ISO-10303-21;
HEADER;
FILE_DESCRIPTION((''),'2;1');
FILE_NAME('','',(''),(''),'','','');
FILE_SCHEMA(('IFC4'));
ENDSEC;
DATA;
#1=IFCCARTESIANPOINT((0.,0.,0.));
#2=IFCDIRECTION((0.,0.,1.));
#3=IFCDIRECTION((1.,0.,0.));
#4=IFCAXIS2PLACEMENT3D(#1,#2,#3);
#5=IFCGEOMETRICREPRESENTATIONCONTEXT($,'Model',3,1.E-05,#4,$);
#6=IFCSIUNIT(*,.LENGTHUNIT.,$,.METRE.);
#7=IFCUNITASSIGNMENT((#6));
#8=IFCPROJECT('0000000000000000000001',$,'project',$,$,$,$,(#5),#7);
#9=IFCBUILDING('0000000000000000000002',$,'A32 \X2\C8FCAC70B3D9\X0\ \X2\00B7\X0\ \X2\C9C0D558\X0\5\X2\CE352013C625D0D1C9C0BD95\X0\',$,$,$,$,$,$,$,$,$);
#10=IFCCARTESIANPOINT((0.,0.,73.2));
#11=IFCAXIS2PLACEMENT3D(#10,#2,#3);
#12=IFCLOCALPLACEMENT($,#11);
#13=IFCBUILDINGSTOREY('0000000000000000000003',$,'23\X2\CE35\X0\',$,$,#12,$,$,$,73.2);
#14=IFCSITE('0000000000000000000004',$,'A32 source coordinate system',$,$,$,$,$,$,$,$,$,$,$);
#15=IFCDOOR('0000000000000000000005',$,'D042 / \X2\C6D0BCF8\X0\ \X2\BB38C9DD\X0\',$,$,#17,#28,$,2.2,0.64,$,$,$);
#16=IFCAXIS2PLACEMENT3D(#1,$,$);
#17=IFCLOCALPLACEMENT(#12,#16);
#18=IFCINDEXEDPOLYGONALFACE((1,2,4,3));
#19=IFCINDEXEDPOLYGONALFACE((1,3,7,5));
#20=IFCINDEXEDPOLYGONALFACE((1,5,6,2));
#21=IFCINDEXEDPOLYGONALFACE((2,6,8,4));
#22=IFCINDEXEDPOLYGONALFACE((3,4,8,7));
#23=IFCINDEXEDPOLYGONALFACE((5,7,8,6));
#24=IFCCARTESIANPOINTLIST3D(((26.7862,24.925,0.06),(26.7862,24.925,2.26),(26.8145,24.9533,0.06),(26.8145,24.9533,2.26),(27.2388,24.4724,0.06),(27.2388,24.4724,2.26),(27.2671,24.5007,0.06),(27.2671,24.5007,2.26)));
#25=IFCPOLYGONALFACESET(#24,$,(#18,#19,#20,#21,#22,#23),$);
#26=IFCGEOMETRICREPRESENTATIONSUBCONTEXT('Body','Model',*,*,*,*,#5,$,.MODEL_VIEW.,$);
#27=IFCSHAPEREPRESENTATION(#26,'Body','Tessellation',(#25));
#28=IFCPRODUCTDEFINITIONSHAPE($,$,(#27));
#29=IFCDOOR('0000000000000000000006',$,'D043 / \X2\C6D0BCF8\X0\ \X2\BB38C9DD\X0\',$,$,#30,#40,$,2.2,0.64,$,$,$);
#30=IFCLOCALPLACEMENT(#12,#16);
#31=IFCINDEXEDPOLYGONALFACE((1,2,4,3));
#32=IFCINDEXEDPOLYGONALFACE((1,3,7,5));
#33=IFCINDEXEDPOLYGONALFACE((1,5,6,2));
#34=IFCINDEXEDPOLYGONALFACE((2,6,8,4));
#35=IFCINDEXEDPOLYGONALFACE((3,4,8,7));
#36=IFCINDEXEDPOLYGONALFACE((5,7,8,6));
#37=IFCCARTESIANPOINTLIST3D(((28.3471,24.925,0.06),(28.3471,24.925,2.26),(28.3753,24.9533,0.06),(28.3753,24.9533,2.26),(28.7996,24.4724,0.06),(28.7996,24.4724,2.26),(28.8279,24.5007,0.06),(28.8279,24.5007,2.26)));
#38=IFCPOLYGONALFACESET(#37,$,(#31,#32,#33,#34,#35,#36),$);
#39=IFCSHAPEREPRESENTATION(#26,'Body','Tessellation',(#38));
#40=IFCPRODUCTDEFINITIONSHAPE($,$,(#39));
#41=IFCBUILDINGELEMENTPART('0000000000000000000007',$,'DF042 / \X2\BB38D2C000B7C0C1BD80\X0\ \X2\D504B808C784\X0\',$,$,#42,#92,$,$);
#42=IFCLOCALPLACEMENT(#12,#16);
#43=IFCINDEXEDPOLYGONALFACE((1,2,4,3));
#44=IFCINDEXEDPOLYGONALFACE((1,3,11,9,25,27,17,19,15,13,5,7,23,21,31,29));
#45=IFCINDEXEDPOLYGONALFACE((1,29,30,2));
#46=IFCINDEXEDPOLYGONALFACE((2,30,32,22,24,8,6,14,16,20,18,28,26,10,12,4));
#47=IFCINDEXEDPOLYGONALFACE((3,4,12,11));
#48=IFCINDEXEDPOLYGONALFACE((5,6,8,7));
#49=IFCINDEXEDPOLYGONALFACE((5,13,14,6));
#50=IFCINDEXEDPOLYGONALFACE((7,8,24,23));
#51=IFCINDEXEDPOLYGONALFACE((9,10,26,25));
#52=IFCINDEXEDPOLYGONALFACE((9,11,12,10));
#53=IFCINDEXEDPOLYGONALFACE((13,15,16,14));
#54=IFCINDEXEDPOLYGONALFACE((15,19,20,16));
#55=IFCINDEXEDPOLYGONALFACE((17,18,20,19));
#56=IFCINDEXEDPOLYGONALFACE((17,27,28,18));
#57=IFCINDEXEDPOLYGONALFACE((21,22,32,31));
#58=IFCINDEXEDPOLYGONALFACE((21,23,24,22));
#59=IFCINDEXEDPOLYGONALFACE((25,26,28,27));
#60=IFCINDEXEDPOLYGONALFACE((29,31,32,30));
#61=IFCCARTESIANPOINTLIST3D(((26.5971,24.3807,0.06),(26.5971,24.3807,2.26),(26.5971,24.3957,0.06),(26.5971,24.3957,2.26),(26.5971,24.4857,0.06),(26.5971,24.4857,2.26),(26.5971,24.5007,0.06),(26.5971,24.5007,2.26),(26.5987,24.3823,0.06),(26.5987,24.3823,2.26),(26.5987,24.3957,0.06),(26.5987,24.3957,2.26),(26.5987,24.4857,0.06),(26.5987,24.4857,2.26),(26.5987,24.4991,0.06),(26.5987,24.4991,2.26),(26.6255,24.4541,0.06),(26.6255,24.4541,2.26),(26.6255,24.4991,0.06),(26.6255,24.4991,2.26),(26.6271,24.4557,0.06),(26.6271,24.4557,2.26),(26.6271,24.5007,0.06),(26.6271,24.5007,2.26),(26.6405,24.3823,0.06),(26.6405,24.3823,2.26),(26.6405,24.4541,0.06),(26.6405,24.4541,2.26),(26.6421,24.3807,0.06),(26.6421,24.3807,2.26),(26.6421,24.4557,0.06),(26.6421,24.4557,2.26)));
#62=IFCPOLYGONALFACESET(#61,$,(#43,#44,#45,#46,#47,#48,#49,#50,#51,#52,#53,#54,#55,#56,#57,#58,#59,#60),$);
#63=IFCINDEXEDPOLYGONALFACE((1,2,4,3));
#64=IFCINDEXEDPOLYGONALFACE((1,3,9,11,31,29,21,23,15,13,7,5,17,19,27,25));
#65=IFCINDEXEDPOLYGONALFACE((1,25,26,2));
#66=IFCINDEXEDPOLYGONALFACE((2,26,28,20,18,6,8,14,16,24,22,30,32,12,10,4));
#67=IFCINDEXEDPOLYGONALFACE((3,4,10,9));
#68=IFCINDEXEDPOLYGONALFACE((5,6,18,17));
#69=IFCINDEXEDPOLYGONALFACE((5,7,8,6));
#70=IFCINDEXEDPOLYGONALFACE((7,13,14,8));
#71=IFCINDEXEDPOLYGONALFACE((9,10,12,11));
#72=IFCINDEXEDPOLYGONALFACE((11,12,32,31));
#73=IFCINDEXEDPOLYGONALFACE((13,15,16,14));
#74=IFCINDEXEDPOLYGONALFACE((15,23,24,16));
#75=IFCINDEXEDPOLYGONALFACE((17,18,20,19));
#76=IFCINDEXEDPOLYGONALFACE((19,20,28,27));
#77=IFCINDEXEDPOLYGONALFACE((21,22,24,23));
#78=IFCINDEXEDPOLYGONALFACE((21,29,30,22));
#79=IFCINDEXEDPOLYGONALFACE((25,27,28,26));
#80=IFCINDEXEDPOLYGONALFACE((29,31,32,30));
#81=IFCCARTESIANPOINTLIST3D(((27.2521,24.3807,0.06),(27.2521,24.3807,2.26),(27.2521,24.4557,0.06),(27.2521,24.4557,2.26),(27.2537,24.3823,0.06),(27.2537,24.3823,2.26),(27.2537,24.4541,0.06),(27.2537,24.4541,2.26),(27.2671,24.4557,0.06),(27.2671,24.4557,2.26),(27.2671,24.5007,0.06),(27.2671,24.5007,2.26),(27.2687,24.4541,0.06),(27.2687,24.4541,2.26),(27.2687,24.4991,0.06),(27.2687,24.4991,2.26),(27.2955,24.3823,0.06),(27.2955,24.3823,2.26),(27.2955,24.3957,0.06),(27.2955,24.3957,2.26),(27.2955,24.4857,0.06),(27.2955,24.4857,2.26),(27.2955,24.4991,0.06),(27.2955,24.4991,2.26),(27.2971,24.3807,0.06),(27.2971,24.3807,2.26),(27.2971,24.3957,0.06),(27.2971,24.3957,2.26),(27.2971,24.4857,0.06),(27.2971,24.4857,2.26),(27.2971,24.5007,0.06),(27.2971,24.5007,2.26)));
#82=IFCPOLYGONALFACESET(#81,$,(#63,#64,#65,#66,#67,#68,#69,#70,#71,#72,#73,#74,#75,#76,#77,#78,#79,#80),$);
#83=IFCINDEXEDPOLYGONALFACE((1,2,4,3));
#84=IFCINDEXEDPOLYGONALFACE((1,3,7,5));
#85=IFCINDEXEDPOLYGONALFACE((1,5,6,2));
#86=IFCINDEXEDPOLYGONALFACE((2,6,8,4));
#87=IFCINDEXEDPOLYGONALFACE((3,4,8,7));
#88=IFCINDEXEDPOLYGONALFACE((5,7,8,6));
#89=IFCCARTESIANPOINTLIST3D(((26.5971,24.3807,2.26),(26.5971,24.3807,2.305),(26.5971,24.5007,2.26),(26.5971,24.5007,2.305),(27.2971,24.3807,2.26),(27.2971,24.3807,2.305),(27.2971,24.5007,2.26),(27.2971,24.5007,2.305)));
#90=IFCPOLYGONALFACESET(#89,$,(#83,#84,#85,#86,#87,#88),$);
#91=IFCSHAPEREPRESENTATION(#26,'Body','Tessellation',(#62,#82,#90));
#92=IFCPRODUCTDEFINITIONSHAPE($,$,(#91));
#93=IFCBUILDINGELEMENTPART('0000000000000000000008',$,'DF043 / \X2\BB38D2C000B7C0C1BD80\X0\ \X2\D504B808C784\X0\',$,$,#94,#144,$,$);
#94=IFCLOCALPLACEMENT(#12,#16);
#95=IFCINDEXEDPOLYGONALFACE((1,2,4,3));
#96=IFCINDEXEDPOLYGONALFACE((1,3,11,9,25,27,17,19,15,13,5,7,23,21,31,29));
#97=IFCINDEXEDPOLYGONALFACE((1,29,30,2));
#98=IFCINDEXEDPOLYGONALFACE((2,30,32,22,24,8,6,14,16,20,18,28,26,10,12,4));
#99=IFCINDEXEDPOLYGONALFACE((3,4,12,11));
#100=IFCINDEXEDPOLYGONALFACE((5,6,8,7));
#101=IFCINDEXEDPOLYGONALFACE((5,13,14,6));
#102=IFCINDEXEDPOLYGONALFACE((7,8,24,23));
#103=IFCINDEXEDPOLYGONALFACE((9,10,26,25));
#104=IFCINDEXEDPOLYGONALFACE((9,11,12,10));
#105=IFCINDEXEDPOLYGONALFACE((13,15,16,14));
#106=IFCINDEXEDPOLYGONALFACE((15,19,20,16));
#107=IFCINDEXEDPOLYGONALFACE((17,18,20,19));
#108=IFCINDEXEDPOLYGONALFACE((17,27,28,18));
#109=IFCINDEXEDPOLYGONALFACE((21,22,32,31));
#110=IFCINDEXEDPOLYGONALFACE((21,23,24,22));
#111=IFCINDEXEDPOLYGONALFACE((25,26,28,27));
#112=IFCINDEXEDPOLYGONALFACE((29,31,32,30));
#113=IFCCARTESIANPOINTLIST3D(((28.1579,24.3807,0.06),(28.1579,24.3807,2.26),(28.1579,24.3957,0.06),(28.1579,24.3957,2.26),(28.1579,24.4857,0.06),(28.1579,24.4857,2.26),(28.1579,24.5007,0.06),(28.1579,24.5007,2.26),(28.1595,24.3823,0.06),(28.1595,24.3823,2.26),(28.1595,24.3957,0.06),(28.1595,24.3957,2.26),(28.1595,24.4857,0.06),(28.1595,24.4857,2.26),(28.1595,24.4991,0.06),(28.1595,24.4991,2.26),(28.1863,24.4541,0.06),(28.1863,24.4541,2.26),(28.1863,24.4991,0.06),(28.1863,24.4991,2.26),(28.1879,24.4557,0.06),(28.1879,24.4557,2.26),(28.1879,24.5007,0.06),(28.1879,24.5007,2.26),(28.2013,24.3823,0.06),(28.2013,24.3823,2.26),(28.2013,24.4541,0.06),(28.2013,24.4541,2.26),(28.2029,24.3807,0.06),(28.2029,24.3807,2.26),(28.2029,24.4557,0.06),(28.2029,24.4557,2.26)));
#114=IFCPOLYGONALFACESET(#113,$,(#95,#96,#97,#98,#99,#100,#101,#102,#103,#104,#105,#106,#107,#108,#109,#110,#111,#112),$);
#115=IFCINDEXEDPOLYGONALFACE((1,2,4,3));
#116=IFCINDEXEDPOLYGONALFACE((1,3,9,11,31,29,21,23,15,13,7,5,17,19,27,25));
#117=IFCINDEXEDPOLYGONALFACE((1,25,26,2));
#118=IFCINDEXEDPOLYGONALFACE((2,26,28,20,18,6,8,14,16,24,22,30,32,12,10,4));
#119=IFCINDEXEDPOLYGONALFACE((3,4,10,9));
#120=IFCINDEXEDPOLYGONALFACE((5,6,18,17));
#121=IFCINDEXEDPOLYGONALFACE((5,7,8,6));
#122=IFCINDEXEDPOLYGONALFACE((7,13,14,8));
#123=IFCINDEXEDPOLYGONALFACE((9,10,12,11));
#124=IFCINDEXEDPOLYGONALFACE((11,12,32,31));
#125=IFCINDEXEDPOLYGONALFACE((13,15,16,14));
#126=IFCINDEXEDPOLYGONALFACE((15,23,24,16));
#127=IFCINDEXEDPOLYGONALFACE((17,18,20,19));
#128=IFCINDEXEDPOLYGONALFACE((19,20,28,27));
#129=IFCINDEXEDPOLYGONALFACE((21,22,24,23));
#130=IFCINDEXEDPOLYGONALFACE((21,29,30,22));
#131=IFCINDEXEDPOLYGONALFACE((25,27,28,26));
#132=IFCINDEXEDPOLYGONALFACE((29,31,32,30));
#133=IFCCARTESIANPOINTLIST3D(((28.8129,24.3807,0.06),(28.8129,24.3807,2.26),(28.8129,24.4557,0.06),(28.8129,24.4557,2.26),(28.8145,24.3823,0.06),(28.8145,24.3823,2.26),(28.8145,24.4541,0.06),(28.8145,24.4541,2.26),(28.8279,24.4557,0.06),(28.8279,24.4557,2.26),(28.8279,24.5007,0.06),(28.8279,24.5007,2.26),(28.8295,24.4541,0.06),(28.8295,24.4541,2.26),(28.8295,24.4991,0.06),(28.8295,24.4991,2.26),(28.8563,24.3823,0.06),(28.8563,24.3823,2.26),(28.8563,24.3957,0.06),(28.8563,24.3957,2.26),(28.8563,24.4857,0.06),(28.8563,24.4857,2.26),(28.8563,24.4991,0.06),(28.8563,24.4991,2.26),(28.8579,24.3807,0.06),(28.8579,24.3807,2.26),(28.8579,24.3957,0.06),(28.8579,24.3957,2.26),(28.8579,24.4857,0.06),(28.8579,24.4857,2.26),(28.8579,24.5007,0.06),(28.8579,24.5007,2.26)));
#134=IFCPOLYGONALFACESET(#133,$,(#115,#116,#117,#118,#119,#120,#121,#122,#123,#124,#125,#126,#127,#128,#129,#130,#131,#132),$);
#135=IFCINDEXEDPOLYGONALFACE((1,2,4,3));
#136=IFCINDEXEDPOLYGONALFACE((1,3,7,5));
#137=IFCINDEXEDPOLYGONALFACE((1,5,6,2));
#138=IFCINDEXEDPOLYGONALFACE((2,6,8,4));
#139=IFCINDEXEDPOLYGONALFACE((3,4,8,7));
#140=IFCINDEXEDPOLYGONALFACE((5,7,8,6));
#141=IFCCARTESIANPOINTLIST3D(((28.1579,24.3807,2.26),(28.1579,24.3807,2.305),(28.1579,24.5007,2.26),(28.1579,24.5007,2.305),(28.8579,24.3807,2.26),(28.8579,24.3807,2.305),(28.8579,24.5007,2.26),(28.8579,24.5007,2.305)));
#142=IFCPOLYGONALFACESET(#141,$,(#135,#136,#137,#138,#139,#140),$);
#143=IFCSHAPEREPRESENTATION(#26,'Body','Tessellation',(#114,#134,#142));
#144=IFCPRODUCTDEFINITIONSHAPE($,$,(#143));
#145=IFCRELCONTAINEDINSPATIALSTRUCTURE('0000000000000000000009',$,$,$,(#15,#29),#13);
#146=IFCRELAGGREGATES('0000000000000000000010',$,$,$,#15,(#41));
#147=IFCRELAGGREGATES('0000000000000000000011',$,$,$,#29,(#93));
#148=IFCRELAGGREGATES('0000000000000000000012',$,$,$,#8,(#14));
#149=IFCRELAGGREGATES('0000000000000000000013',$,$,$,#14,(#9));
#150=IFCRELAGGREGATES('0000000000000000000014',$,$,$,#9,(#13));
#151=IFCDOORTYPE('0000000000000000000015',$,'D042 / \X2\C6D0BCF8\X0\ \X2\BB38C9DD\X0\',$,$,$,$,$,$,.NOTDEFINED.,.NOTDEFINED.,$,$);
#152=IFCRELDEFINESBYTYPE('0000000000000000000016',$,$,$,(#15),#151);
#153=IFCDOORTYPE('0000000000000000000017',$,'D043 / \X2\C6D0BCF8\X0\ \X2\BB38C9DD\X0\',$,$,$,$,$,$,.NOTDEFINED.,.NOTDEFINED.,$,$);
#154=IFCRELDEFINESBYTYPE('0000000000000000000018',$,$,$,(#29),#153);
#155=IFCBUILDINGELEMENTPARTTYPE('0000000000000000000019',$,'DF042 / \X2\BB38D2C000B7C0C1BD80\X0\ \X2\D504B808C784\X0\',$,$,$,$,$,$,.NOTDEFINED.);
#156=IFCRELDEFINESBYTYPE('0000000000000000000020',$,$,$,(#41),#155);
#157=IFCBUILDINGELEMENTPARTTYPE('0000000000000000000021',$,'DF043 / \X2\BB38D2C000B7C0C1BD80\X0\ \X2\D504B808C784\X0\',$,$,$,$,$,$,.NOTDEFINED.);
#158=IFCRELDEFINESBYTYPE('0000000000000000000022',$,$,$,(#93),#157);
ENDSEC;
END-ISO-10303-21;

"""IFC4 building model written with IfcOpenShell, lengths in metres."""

from ifc_helpers import new_model, si_unit, frame, origin, origin_with_axes, place, context, subcontext, project, spatial, polyline, outline, extrude, source, transform, mapped, type_object, type_shapes, element, aggregate, save


model = new_model("IFC4")

# Units and contexts
model_context = context("Model", 3, precision=1e-05, world=origin_with_axes())
body_context = subcontext(model_context, "Body", "Model", "MODEL_VIEW")
ifc_project = project(units=[si_unit("LENGTHUNIT", "METRE")], contexts=[model_context])

# Site, building, storey
site = spatial("IfcSite", under=ifc_project, Name="A32 source coordinate system")
building = spatial("IfcBuilding", under=site, Name="A32 주거동 · 지하5층–옥탑지붕")
storey_placement = place(None, frame((0.0, 0.0, 73.2), z_axis=(0.0, 0.0, 1.0), x_axis=(1.0, 0.0, 0.0)))
storey = spatial("IfcBuildingStorey", under=building, at=storey_placement, Name="23층", Elevation=73.2)

# Doors
door_type_1 = type_object("IfcDoorType", Name="D042 / 원본 문짝", OperationType="NOTDEFINED", PredefinedType="NOTDEFINED")
shared_shape_1 = source(origin(), body_context, "Body", "SweptSolid", [
    extrude(outline(polyline([(27.2671, 24.5007), (27.2388, 24.4724), (26.7862, 24.925), (26.8145, 24.9533), (27.2671, 24.5007)])), frame((0.0, 0.0, 0.06)), (0.0, 0.0, 1.0), 2.2),
])
type_shapes(door_type_1, [shared_shape_1])
door_1_placement = place(storey_placement, origin_with_axes())
door_1 = element("IfcDoor", 1, at=door_1_placement, inside=storey, type_object=door_type_1, Name="D042 / 원본 문짝", OverallHeight=2.2, OverallWidth=0.64, context=body_context, shape_type="MappedRepresentation", body=[
    mapped(shared_shape_1, transform((0.0, 0.0, 0.0), scale=1.0)),
])
door_type_2 = type_object("IfcDoorType", Name="D043 / 원본 문짝", OperationType="NOTDEFINED", PredefinedType="NOTDEFINED")
shared_shape_2 = source(origin(), body_context, "Body", "SweptSolid", [
    extrude(outline(polyline([(28.8279, 24.5007), (28.7996, 24.4724), (28.3471, 24.925), (28.3753, 24.9533), (28.8279, 24.5007)])), frame((0.0, 0.0, 0.06)), (0.0, 0.0, 1.0), 2.2),
])
type_shapes(door_type_2, [shared_shape_2])
door_2_placement = place(storey_placement, origin_with_axes())
door_2 = element("IfcDoor", 2, at=door_2_placement, inside=storey, type_object=door_type_2, Name="D043 / 원본 문짝", OverallHeight=2.2, OverallWidth=0.64, context=body_context, shape_type="MappedRepresentation", body=[
    mapped(shared_shape_2, transform((0.0, 0.0, 0.0), scale=1.0)),
])

# Building element parts
building_element_part_type_1 = type_object("IfcBuildingElementPartType", Name="DF042 / 문틀·상부 프레임", PredefinedType="NOTDEFINED")
shared_shape_3 = source(origin(), body_context, "Body", "SweptSolid", [
    extrude(outline(polyline([(26.5971, 24.4857), (26.5971, 24.5007), (26.6271, 24.5007), (26.6271, 24.4557), (26.6421, 24.4557), (26.6421, 24.3807), (26.5971, 24.3807), (26.5971, 24.3957), (26.5987, 24.3957), (26.5987, 24.3823), (26.6405, 24.3823), (26.6405, 24.4541), (26.6255, 24.4541), (26.6255, 24.4991), (26.5987, 24.4991), (26.5987, 24.4857), (26.5971, 24.4857)])), frame((0.0, 0.0, 0.06)), (0.0, 0.0, 1.0), 2.2),
    extrude(outline(polyline([(27.2955, 24.4991), (27.2687, 24.4991), (27.2687, 24.4541), (27.2537, 24.4541), (27.2537, 24.3823), (27.2955, 24.3823), (27.2955, 24.3957), (27.2971, 24.3957), (27.2971, 24.3807), (27.2521, 24.3807), (27.2521, 24.4557), (27.2671, 24.4557), (27.2671, 24.5007), (27.2971, 24.5007), (27.2971, 24.4857), (27.2955, 24.4857), (27.2955, 24.4991)])), frame((0.0, 0.0, 0.06)), (0.0, 0.0, 1.0), 2.2),
    extrude(outline(polyline([(26.5971, 24.3807), (26.5971, 24.5007), (27.2971, 24.5007), (27.2971, 24.3807), (26.5971, 24.3807)])), frame((0.0, 0.0, 2.26)), (0.0, 0.0, 1.0), 0.045),
])
type_shapes(building_element_part_type_1, [shared_shape_3])
building_element_part_1_placement = place(door_1_placement, origin_with_axes())
building_element_part_1 = element("IfcBuildingElementPart", 3, at=building_element_part_1_placement, type_object=building_element_part_type_1, Name="DF042 / 문틀·상부 프레임", context=body_context, shape_type="MappedRepresentation", body=[
    mapped(shared_shape_3, transform((0.0, 0.0, 0.0), scale=1.0)),
])
aggregate(door_1, [building_element_part_1])
building_element_part_type_2 = type_object("IfcBuildingElementPartType", Name="DF043 / 문틀·상부 프레임", PredefinedType="NOTDEFINED")
shared_shape_4 = source(origin(), body_context, "Body", "SweptSolid", [
    extrude(outline(polyline([(28.1579, 24.4857), (28.1579, 24.5007), (28.1879, 24.5007), (28.1879, 24.4557), (28.2029, 24.4557), (28.2029, 24.3807), (28.1579, 24.3807), (28.1579, 24.3957), (28.1595, 24.3957), (28.1595, 24.3823), (28.2013, 24.3823), (28.2013, 24.4541), (28.1863, 24.4541), (28.1863, 24.4991), (28.1595, 24.4991), (28.1595, 24.4857), (28.1579, 24.4857)])), frame((0.0, 0.0, 0.06)), (0.0, 0.0, 1.0), 2.2),
    extrude(outline(polyline([(28.8563, 24.4991), (28.8295, 24.4991), (28.8295, 24.4541), (28.8145, 24.4541), (28.8145, 24.3823), (28.8563, 24.3823), (28.8563, 24.3957), (28.8579, 24.3957), (28.8579, 24.3807), (28.8129, 24.3807), (28.8129, 24.4557), (28.8279, 24.4557), (28.8279, 24.5007), (28.8579, 24.5007), (28.8579, 24.4857), (28.8563, 24.4857), (28.8563, 24.4991)])), frame((0.0, 0.0, 0.06)), (0.0, 0.0, 1.0), 2.2),
    extrude(outline(polyline([(28.1579, 24.3807), (28.1579, 24.5007), (28.8579, 24.5007), (28.8579, 24.3807), (28.1579, 24.3807)])), frame((0.0, 0.0, 2.26)), (0.0, 0.0, 1.0), 0.045),
])
type_shapes(building_element_part_type_2, [shared_shape_4])
building_element_part_2_placement = place(door_2_placement, origin_with_axes())
building_element_part_2 = element("IfcBuildingElementPart", 4, at=building_element_part_2_placement, type_object=building_element_part_type_2, Name="DF043 / 문틀·상부 프레임", context=body_context, shape_type="MappedRepresentation", body=[
    mapped(shared_shape_4, transform((0.0, 0.0, 0.0), scale=1.0)),
])
aggregate(door_2, [building_element_part_2])

save(model, "model.ifc")
